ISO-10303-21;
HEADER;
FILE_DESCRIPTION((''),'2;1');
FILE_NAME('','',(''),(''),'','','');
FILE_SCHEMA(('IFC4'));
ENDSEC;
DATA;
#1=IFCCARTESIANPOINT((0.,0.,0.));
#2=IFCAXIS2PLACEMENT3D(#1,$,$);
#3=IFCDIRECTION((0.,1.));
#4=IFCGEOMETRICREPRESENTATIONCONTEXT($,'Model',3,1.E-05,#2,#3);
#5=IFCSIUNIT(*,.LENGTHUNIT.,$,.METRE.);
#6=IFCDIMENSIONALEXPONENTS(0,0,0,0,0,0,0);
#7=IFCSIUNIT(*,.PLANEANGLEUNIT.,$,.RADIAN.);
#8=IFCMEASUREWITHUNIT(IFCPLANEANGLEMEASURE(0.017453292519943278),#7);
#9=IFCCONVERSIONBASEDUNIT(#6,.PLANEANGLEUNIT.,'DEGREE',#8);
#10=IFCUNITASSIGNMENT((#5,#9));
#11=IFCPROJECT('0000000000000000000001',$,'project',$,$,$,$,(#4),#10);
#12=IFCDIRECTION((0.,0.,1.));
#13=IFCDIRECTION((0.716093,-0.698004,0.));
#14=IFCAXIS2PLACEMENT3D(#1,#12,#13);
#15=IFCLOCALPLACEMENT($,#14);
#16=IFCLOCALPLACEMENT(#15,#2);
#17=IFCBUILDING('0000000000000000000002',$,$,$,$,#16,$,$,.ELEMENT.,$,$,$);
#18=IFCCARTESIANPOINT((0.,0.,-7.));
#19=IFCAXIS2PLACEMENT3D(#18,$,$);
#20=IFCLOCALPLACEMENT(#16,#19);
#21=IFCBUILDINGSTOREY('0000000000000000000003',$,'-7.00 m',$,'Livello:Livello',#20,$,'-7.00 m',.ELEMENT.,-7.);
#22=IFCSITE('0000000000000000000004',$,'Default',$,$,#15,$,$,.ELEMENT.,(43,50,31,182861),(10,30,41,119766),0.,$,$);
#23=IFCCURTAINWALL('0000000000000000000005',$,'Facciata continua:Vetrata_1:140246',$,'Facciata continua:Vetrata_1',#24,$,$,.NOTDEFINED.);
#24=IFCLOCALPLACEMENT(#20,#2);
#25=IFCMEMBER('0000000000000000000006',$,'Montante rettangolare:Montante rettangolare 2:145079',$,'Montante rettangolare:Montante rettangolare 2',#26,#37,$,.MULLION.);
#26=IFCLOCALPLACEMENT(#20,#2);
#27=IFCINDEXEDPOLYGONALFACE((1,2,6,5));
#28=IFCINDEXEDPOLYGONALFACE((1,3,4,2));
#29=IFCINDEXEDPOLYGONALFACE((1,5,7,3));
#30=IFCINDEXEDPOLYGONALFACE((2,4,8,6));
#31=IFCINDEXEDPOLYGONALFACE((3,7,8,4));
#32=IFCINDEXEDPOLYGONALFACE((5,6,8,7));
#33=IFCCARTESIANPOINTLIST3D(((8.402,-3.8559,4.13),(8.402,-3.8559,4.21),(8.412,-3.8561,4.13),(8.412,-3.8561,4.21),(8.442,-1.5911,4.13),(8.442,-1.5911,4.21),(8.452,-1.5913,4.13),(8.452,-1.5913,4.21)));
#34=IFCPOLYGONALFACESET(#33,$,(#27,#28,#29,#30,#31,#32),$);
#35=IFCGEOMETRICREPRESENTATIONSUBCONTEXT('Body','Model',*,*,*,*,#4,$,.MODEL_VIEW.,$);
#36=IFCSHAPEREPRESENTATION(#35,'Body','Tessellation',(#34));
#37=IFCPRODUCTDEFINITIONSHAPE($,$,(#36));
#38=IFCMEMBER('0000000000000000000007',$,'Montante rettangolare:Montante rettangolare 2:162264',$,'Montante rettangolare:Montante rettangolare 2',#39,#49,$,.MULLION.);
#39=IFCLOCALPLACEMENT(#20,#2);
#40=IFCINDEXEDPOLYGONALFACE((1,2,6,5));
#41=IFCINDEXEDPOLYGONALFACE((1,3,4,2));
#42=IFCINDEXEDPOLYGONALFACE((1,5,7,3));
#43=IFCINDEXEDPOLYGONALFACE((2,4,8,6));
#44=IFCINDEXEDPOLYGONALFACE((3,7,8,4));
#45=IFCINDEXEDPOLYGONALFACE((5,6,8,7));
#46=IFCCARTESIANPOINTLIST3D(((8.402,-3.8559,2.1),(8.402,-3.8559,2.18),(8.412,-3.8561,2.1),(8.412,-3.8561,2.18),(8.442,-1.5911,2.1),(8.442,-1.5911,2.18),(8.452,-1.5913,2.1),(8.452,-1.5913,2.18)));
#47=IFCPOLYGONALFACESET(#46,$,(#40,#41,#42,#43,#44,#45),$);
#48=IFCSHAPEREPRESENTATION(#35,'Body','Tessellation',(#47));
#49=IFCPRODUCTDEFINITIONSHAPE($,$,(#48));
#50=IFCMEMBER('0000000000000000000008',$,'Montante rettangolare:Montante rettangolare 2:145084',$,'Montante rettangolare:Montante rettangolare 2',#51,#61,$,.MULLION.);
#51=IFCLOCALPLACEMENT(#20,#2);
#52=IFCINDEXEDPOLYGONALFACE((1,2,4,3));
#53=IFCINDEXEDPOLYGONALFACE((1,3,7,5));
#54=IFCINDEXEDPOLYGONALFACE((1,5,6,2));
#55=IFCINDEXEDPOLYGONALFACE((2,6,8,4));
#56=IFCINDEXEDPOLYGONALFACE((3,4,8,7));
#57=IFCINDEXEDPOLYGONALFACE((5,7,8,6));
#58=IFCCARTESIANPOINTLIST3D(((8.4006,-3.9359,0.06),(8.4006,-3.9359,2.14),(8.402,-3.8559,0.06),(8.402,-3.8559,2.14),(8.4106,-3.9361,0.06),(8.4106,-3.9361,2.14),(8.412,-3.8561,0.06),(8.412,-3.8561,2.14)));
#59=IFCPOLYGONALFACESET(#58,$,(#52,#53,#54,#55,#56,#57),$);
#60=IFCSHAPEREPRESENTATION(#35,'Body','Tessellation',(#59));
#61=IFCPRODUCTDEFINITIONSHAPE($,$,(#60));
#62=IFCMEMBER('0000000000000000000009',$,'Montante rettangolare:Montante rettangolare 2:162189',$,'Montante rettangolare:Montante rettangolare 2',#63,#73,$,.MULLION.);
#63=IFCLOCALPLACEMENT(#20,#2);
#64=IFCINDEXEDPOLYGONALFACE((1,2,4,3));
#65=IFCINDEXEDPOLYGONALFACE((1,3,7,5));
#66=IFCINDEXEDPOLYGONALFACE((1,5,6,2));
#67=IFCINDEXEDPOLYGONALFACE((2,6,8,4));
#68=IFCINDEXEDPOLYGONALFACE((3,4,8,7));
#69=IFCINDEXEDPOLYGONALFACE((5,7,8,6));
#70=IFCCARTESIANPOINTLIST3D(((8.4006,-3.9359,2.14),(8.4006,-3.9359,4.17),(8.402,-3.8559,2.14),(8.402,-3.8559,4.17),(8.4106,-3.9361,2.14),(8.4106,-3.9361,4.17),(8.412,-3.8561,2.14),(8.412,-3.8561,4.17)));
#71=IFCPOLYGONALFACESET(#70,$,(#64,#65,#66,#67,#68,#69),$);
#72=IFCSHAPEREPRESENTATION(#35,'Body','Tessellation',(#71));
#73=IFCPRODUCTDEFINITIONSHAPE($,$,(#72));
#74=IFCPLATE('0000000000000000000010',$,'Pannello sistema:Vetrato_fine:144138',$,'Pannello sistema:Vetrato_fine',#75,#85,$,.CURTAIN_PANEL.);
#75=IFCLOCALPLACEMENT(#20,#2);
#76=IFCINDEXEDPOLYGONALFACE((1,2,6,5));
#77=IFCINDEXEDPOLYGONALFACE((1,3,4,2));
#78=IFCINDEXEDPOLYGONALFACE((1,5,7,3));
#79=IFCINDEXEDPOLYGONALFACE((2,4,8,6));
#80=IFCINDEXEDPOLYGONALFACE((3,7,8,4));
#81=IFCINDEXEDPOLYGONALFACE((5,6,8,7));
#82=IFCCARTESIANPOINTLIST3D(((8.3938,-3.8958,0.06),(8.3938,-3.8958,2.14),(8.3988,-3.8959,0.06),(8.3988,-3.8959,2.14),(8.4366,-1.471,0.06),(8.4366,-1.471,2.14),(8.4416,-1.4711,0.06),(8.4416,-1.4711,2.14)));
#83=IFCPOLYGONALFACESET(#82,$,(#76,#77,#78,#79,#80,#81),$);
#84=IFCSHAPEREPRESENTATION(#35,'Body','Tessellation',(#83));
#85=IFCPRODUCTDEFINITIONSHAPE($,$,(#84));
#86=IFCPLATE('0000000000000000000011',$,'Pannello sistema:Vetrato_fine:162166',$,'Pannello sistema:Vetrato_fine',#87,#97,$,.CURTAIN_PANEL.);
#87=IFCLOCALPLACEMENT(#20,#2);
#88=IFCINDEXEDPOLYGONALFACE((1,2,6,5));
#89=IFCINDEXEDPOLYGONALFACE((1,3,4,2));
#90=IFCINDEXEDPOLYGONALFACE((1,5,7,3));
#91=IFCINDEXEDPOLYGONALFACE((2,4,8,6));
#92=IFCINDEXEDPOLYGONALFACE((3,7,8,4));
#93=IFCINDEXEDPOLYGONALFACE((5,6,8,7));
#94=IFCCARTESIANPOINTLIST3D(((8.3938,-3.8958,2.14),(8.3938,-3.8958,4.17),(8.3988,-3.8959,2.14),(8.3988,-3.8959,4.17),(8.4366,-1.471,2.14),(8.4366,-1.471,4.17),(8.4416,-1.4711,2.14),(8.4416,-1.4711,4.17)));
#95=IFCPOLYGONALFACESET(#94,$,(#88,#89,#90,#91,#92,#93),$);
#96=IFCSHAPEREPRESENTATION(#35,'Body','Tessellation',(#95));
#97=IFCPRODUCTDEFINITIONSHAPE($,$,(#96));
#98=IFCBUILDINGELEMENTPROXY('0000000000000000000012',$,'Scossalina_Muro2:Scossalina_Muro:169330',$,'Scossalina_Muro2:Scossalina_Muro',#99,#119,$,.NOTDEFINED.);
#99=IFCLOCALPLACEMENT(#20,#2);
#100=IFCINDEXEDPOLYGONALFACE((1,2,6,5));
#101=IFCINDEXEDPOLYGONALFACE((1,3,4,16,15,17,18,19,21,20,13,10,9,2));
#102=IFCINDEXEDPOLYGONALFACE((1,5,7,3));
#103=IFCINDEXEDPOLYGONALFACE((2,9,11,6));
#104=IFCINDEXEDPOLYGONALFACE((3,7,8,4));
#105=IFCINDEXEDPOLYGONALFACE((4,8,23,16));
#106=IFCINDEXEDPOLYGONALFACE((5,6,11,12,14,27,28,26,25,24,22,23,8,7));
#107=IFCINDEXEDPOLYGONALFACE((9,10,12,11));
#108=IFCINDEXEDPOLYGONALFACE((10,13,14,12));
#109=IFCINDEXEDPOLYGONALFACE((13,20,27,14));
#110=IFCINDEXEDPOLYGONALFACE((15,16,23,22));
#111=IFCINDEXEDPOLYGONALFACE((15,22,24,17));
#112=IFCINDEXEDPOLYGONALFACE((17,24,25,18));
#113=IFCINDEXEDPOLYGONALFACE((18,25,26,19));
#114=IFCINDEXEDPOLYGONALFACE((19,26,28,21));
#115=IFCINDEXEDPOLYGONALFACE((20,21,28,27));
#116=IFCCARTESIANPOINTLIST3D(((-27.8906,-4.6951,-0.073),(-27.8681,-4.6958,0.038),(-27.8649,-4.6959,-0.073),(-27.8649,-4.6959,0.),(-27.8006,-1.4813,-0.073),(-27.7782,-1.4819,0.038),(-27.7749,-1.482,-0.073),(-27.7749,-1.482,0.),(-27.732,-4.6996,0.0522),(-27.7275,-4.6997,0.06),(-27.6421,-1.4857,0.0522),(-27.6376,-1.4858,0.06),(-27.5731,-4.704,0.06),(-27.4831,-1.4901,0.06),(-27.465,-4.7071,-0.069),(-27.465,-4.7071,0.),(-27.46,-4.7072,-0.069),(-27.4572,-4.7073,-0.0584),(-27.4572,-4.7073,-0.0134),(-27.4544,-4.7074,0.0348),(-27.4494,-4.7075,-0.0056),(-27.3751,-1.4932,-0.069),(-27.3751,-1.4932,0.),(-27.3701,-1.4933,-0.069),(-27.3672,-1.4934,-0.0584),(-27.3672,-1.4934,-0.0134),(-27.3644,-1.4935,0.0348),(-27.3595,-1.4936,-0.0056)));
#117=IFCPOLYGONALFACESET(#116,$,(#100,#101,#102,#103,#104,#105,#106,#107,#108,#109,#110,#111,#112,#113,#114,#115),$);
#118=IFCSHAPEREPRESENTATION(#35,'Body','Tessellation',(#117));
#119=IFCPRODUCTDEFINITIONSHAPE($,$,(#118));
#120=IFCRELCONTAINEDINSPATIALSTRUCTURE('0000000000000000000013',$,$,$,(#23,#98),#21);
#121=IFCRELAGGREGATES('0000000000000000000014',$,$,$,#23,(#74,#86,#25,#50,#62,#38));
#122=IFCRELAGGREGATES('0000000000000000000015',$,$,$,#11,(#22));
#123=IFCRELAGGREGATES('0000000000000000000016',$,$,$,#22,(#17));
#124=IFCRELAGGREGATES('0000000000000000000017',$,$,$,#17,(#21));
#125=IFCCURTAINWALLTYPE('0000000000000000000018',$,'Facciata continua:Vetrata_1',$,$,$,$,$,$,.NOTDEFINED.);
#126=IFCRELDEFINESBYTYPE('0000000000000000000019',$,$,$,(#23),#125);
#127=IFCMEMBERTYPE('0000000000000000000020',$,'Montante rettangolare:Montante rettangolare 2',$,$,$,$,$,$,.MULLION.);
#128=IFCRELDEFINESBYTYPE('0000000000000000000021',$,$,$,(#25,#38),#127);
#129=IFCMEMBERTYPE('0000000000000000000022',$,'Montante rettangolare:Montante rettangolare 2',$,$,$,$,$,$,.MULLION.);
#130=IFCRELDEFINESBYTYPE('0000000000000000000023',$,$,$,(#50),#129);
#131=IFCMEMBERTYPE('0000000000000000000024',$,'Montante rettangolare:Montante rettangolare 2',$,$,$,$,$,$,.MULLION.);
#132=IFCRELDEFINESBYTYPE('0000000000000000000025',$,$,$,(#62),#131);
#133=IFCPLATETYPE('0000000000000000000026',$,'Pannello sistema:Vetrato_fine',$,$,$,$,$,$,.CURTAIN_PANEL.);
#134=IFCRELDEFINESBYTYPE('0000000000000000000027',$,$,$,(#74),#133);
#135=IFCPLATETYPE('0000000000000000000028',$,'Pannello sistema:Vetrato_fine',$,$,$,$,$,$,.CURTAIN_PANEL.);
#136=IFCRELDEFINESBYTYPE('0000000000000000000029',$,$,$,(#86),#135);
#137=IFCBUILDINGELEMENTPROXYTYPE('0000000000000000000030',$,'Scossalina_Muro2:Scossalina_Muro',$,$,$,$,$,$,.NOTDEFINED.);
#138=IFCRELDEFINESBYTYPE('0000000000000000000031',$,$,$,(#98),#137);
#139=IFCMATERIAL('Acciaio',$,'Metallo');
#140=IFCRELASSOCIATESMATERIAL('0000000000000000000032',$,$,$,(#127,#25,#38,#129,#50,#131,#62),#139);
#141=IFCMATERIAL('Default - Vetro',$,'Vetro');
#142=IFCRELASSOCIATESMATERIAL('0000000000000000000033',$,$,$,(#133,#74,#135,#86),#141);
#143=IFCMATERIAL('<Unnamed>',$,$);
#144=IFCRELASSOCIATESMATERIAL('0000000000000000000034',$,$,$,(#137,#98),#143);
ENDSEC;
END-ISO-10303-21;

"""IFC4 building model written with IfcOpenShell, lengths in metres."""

from ifc_helpers import new_model, entity, si_unit, converted_unit, direction, frame, origin, place, context, subcontext, project, spatial, indexed_curve, outline, extrude, source, transform, mapped, material, type_object, type_shapes, element, aggregate, save


model = new_model("IFC4")

# Units and contexts
model_context = context("Model", 3, precision=1e-05, world=origin(), true_north=direction((0.0, 1.0)))
body_context = subcontext(model_context, "Body", "Model", "MODEL_VIEW")
ifc_project = project(units=[si_unit("LENGTHUNIT", "METRE"), converted_unit("PLANEANGLEUNIT", "DEGREE", entity("IfcPlaneAngleMeasure", 0.017453292519943278), si_unit("PLANEANGLEUNIT", "RADIAN"), dimensions=[0, 0, 0, 0, 0, 0, 0])], contexts=[model_context])

# Site, building, storey
site_placement = place(None, frame((0.0, 0.0, 0.0), z_axis=(0.0, 0.0, 1.0), x_axis=(0.716093, -0.698004, 0.0)))
site = spatial("IfcSite", under=ifc_project, at=site_placement, Name="Default", CompositionType="ELEMENT", RefLatitude=(43, 50, 31, 182861), RefLongitude=(10, 30, 41, 119766), RefElevation=0.0)
building_placement = place(site_placement, origin())
building = spatial("IfcBuilding", under=site, at=building_placement, CompositionType="ELEMENT")
storey_placement = place(building_placement, frame((0.0, 0.0, -7.0)))
storey = spatial("IfcBuildingStorey", under=building, at=storey_placement, Name="-7.00 m", ObjectType="Livello:Livello", LongName="-7.00 m", CompositionType="ELEMENT", Elevation=-7.0)

# Curtain wall
ifc_material_1 = material(Name="Acciaio", Category="Metallo")
curtain_wall_type_1 = type_object("IfcCurtainWallType", Name="Facciata continua:Vetrata_1", PredefinedType="NOTDEFINED")
curtain_wall_1_placement = place(storey_placement, frame((0.0, 0.0, 7.0)))
curtain_wall_1 = element("IfcCurtainWall", 1, at=curtain_wall_1_placement, inside=storey, type_object=curtain_wall_type_1, Name="Facciata continua:Vetrata_1:140246", ObjectType="Facciata continua:Vetrata_1", PredefinedType="NOTDEFINED")

# Members
member_type_1 = type_object("IfcMemberType", Name="Montante rettangolare:Montante rettangolare 2", PredefinedType="MULLION", material=ifc_material_1)
shared_shape_1 = source(origin(), body_context, "Body", "SweptSolid", [
    extrude(outline(indexed_curve([(-0.04, -0.005), (0.04, -0.005), (0.04, 0.005), (-0.04, 0.005), (-0.04, -0.005)], self_intersect=False)), frame((0.0, 0.01, -2.2652), z_axis=(0.0, 0.0, 1.0), x_axis=(-1.0, 0.0, 0.0)), (0.0, 0.0, 1.0), 2.2652),
])
type_shapes(member_type_1, [shared_shape_1])
member_1_placement = place(curtain_wall_1_placement, frame((8.437, -1.591, -2.83), z_axis=(0.017636, 0.999844, 0.0), x_axis=(0.0, 0.0, 1.0)))
member_1 = element("IfcMember", 2, at=member_1_placement, type_object=member_type_1, material=ifc_material_1, Name="Montante rettangolare:Montante rettangolare 2:145079", ObjectType="Montante rettangolare:Montante rettangolare 2", PredefinedType="MULLION", context=body_context, shape_type="MappedRepresentation", body=[
    mapped(shared_shape_1, transform((0.0, 0.0, 0.0), scale=1.0)),
])
member_2_placement = place(curtain_wall_1_placement, frame((8.437, -1.591, -4.86), z_axis=(0.017636, 0.999844, 0.0), x_axis=(0.0, 0.0, 1.0)))
member_2 = element("IfcMember", 3, at=member_2_placement, type_object=member_type_1, material=ifc_material_1, Name="Montante rettangolare:Montante rettangolare 2:162264", ObjectType="Montante rettangolare:Montante rettangolare 2", PredefinedType="MULLION", context=body_context, shape_type="MappedRepresentation", body=[
    mapped(shared_shape_1, transform((0.0, 0.0, 0.0), scale=1.0)),
])
member_type_2 = type_object("IfcMemberType", Name="Montante rettangolare:Montante rettangolare 2", PredefinedType="MULLION", material=ifc_material_1)
shared_shape_2 = source(origin(), body_context, "Body", "SweptSolid", [
    extrude(outline(indexed_curve([(-0.04, -0.005), (0.04, -0.005), (0.04, 0.005), (-0.04, 0.005), (-0.04, -0.005)], self_intersect=False)), frame((0.0, 0.01, -2.08), z_axis=(0.0, 0.0, 1.0), x_axis=(-1.0, 0.0, 0.0)), (0.0, 0.0, 1.0), 2.08),
])
type_shapes(member_type_2, [shared_shape_2])
member_3_placement = place(curtain_wall_1_placement, frame((8.3963, -3.8958, -6.94), z_axis=(0.0, 0.0, -1.0), x_axis=(0.017636, 0.999844, 0.0)))
member_3 = element("IfcMember", 4, at=member_3_placement, type_object=member_type_2, material=ifc_material_1, Name="Montante rettangolare:Montante rettangolare 2:145084", ObjectType="Montante rettangolare:Montante rettangolare 2", PredefinedType="MULLION", context=body_context, shape_type="MappedRepresentation", body=[
    mapped(shared_shape_2, transform((0.0, 0.0, 0.0), scale=1.0)),
])
member_type_3 = type_object("IfcMemberType", Name="Montante rettangolare:Montante rettangolare 2", PredefinedType="MULLION", material=ifc_material_1)
shared_shape_3 = source(origin(), body_context, "Body", "SweptSolid", [
    extrude(outline(indexed_curve([(-0.04, -0.005), (0.04, -0.005), (0.04, 0.005), (-0.04, 0.005), (-0.04, -0.005)], self_intersect=False)), frame((0.0, 0.01, -2.03), z_axis=(0.0, 0.0, 1.0), x_axis=(-1.0, 0.0, 0.0)), (0.0, 0.0, 1.0), 2.03),
])
type_shapes(member_type_3, [shared_shape_3])
member_4_placement = place(curtain_wall_1_placement, frame((8.3963, -3.8958, -4.86), z_axis=(0.0, 0.0, -1.0), x_axis=(0.017636, 0.999844, 0.0)))
member_4 = element("IfcMember", 5, at=member_4_placement, type_object=member_type_3, material=ifc_material_1, Name="Montante rettangolare:Montante rettangolare 2:162189", ObjectType="Montante rettangolare:Montante rettangolare 2", PredefinedType="MULLION", context=body_context, shape_type="MappedRepresentation", body=[
    mapped(shared_shape_3, transform((0.0, 0.0, 0.0), scale=1.0)),
])

# Plates
ifc_material_2 = material(Name="Default - Vetro", Category="Vetro")
plate_type_1 = type_object("IfcPlateType", Name="Pannello sistema:Vetrato_fine", PredefinedType="CURTAIN_PANEL", material=ifc_material_2)
shared_shape_4 = source(origin(), body_context, "Body", "SweptSolid", [
    extrude(outline(indexed_curve([(-0.0025, -1.2126), (0.0025, -1.2126), (0.0025, 1.2126), (-0.0025, 1.2126), (-0.0025, -1.2126)], self_intersect=False)), frame((0.0, 0.0, 0.0), z_axis=(0.0, 0.0, 1.0), x_axis=(0.0, 1.0, 0.0)), (0.0, 0.0, 1.0), 2.08),
])
type_shapes(plate_type_1, [shared_shape_4])
plate_1_placement = place(curtain_wall_1_placement, frame((8.4177, -2.6834, -6.94), z_axis=(0.0, 0.0, 1.0), x_axis=(0.017636, 0.999844, 0.0)))
plate_1 = element("IfcPlate", 6, at=plate_1_placement, type_object=plate_type_1, material=ifc_material_2, Name="Pannello sistema:Vetrato_fine:144138", ObjectType="Pannello sistema:Vetrato_fine", PredefinedType="CURTAIN_PANEL", context=body_context, shape_type="MappedRepresentation", body=[
    mapped(shared_shape_4, transform((0.0, 0.0, 0.0), scale=1.0)),
])
plate_type_2 = type_object("IfcPlateType", Name="Pannello sistema:Vetrato_fine", PredefinedType="CURTAIN_PANEL", material=ifc_material_2)
shared_shape_5 = source(origin(), body_context, "Body", "SweptSolid", [
    extrude(outline(indexed_curve([(-0.0025, -1.2126), (0.0025, -1.2126), (0.0025, 1.2126), (-0.0025, 1.2126), (-0.0025, -1.2126)], self_intersect=False)), frame((0.0, 0.0, 0.0), z_axis=(0.0, 0.0, 1.0), x_axis=(0.0, 1.0, 0.0)), (0.0, 0.0, 1.0), 2.03),
])
type_shapes(plate_type_2, [shared_shape_5])
plate_2_placement = place(curtain_wall_1_placement, frame((8.4177, -2.6834, -4.86), z_axis=(0.0, 0.0, 1.0), x_axis=(0.017636, 0.999844, 0.0)))
plate_2 = element("IfcPlate", 7, at=plate_2_placement, type_object=plate_type_2, material=ifc_material_2, Name="Pannello sistema:Vetrato_fine:162166", ObjectType="Pannello sistema:Vetrato_fine", PredefinedType="CURTAIN_PANEL", context=body_context, shape_type="MappedRepresentation", body=[
    mapped(shared_shape_5, transform((0.0, 0.0, 0.0), scale=1.0)),
])
aggregate(curtain_wall_1, [plate_1, plate_2, member_1, member_3, member_4, member_2])

# Building element proxy
ifc_material_3 = material(Name="<Unnamed>")
building_element_proxy_type_1 = type_object("IfcBuildingElementProxyType", Name="Scossalina_Muro2:Scossalina_Muro", PredefinedType="NOTDEFINED", material=ifc_material_3)
shared_shape_6 = source(origin(), body_context, "Body", "SweptSolid", [
    extrude(outline(indexed_curve([(-0.104, -0.0683), (0.0505, -0.0683), (0.1692, -0.0431), (0.1742, -0.0027), (0.1664, 0.0051), (0.1664, 0.0501), (0.1636, 0.0607), (0.1586, 0.0607), (0.1586, -0.0083), (-0.2414, -0.0083), (-0.2414, 0.0647), (-0.2671, 0.0647), (-0.2447, -0.0463), (-0.1085, -0.0605), (-0.104, -0.0683)], self_intersect=False)), frame((-27.6235, -4.7026, -7.0083), z_axis=(0.02798, 0.999608, 0.0), x_axis=(0.999608, -0.02798, 0.0)), (0.0, 0.0, 1.0), 3.2151),
])
type_shapes(building_element_proxy_type_1, [shared_shape_6])
proxy_1_placement = place(storey_placement, frame((0.0, 0.0, 7.0)))
element("IfcBuildingElementProxy", 8, at=proxy_1_placement, inside=storey, type_object=building_element_proxy_type_1, material=ifc_material_3, Name="Scossalina_Muro2:Scossalina_Muro:169330", ObjectType="Scossalina_Muro2:Scossalina_Muro", PredefinedType="NOTDEFINED", context=body_context, shape_type="MappedRepresentation", body=[
    mapped(shared_shape_6, transform((0.0, 0.0, 0.0), scale=1.0)),
])

save(model, "model.ifc")
